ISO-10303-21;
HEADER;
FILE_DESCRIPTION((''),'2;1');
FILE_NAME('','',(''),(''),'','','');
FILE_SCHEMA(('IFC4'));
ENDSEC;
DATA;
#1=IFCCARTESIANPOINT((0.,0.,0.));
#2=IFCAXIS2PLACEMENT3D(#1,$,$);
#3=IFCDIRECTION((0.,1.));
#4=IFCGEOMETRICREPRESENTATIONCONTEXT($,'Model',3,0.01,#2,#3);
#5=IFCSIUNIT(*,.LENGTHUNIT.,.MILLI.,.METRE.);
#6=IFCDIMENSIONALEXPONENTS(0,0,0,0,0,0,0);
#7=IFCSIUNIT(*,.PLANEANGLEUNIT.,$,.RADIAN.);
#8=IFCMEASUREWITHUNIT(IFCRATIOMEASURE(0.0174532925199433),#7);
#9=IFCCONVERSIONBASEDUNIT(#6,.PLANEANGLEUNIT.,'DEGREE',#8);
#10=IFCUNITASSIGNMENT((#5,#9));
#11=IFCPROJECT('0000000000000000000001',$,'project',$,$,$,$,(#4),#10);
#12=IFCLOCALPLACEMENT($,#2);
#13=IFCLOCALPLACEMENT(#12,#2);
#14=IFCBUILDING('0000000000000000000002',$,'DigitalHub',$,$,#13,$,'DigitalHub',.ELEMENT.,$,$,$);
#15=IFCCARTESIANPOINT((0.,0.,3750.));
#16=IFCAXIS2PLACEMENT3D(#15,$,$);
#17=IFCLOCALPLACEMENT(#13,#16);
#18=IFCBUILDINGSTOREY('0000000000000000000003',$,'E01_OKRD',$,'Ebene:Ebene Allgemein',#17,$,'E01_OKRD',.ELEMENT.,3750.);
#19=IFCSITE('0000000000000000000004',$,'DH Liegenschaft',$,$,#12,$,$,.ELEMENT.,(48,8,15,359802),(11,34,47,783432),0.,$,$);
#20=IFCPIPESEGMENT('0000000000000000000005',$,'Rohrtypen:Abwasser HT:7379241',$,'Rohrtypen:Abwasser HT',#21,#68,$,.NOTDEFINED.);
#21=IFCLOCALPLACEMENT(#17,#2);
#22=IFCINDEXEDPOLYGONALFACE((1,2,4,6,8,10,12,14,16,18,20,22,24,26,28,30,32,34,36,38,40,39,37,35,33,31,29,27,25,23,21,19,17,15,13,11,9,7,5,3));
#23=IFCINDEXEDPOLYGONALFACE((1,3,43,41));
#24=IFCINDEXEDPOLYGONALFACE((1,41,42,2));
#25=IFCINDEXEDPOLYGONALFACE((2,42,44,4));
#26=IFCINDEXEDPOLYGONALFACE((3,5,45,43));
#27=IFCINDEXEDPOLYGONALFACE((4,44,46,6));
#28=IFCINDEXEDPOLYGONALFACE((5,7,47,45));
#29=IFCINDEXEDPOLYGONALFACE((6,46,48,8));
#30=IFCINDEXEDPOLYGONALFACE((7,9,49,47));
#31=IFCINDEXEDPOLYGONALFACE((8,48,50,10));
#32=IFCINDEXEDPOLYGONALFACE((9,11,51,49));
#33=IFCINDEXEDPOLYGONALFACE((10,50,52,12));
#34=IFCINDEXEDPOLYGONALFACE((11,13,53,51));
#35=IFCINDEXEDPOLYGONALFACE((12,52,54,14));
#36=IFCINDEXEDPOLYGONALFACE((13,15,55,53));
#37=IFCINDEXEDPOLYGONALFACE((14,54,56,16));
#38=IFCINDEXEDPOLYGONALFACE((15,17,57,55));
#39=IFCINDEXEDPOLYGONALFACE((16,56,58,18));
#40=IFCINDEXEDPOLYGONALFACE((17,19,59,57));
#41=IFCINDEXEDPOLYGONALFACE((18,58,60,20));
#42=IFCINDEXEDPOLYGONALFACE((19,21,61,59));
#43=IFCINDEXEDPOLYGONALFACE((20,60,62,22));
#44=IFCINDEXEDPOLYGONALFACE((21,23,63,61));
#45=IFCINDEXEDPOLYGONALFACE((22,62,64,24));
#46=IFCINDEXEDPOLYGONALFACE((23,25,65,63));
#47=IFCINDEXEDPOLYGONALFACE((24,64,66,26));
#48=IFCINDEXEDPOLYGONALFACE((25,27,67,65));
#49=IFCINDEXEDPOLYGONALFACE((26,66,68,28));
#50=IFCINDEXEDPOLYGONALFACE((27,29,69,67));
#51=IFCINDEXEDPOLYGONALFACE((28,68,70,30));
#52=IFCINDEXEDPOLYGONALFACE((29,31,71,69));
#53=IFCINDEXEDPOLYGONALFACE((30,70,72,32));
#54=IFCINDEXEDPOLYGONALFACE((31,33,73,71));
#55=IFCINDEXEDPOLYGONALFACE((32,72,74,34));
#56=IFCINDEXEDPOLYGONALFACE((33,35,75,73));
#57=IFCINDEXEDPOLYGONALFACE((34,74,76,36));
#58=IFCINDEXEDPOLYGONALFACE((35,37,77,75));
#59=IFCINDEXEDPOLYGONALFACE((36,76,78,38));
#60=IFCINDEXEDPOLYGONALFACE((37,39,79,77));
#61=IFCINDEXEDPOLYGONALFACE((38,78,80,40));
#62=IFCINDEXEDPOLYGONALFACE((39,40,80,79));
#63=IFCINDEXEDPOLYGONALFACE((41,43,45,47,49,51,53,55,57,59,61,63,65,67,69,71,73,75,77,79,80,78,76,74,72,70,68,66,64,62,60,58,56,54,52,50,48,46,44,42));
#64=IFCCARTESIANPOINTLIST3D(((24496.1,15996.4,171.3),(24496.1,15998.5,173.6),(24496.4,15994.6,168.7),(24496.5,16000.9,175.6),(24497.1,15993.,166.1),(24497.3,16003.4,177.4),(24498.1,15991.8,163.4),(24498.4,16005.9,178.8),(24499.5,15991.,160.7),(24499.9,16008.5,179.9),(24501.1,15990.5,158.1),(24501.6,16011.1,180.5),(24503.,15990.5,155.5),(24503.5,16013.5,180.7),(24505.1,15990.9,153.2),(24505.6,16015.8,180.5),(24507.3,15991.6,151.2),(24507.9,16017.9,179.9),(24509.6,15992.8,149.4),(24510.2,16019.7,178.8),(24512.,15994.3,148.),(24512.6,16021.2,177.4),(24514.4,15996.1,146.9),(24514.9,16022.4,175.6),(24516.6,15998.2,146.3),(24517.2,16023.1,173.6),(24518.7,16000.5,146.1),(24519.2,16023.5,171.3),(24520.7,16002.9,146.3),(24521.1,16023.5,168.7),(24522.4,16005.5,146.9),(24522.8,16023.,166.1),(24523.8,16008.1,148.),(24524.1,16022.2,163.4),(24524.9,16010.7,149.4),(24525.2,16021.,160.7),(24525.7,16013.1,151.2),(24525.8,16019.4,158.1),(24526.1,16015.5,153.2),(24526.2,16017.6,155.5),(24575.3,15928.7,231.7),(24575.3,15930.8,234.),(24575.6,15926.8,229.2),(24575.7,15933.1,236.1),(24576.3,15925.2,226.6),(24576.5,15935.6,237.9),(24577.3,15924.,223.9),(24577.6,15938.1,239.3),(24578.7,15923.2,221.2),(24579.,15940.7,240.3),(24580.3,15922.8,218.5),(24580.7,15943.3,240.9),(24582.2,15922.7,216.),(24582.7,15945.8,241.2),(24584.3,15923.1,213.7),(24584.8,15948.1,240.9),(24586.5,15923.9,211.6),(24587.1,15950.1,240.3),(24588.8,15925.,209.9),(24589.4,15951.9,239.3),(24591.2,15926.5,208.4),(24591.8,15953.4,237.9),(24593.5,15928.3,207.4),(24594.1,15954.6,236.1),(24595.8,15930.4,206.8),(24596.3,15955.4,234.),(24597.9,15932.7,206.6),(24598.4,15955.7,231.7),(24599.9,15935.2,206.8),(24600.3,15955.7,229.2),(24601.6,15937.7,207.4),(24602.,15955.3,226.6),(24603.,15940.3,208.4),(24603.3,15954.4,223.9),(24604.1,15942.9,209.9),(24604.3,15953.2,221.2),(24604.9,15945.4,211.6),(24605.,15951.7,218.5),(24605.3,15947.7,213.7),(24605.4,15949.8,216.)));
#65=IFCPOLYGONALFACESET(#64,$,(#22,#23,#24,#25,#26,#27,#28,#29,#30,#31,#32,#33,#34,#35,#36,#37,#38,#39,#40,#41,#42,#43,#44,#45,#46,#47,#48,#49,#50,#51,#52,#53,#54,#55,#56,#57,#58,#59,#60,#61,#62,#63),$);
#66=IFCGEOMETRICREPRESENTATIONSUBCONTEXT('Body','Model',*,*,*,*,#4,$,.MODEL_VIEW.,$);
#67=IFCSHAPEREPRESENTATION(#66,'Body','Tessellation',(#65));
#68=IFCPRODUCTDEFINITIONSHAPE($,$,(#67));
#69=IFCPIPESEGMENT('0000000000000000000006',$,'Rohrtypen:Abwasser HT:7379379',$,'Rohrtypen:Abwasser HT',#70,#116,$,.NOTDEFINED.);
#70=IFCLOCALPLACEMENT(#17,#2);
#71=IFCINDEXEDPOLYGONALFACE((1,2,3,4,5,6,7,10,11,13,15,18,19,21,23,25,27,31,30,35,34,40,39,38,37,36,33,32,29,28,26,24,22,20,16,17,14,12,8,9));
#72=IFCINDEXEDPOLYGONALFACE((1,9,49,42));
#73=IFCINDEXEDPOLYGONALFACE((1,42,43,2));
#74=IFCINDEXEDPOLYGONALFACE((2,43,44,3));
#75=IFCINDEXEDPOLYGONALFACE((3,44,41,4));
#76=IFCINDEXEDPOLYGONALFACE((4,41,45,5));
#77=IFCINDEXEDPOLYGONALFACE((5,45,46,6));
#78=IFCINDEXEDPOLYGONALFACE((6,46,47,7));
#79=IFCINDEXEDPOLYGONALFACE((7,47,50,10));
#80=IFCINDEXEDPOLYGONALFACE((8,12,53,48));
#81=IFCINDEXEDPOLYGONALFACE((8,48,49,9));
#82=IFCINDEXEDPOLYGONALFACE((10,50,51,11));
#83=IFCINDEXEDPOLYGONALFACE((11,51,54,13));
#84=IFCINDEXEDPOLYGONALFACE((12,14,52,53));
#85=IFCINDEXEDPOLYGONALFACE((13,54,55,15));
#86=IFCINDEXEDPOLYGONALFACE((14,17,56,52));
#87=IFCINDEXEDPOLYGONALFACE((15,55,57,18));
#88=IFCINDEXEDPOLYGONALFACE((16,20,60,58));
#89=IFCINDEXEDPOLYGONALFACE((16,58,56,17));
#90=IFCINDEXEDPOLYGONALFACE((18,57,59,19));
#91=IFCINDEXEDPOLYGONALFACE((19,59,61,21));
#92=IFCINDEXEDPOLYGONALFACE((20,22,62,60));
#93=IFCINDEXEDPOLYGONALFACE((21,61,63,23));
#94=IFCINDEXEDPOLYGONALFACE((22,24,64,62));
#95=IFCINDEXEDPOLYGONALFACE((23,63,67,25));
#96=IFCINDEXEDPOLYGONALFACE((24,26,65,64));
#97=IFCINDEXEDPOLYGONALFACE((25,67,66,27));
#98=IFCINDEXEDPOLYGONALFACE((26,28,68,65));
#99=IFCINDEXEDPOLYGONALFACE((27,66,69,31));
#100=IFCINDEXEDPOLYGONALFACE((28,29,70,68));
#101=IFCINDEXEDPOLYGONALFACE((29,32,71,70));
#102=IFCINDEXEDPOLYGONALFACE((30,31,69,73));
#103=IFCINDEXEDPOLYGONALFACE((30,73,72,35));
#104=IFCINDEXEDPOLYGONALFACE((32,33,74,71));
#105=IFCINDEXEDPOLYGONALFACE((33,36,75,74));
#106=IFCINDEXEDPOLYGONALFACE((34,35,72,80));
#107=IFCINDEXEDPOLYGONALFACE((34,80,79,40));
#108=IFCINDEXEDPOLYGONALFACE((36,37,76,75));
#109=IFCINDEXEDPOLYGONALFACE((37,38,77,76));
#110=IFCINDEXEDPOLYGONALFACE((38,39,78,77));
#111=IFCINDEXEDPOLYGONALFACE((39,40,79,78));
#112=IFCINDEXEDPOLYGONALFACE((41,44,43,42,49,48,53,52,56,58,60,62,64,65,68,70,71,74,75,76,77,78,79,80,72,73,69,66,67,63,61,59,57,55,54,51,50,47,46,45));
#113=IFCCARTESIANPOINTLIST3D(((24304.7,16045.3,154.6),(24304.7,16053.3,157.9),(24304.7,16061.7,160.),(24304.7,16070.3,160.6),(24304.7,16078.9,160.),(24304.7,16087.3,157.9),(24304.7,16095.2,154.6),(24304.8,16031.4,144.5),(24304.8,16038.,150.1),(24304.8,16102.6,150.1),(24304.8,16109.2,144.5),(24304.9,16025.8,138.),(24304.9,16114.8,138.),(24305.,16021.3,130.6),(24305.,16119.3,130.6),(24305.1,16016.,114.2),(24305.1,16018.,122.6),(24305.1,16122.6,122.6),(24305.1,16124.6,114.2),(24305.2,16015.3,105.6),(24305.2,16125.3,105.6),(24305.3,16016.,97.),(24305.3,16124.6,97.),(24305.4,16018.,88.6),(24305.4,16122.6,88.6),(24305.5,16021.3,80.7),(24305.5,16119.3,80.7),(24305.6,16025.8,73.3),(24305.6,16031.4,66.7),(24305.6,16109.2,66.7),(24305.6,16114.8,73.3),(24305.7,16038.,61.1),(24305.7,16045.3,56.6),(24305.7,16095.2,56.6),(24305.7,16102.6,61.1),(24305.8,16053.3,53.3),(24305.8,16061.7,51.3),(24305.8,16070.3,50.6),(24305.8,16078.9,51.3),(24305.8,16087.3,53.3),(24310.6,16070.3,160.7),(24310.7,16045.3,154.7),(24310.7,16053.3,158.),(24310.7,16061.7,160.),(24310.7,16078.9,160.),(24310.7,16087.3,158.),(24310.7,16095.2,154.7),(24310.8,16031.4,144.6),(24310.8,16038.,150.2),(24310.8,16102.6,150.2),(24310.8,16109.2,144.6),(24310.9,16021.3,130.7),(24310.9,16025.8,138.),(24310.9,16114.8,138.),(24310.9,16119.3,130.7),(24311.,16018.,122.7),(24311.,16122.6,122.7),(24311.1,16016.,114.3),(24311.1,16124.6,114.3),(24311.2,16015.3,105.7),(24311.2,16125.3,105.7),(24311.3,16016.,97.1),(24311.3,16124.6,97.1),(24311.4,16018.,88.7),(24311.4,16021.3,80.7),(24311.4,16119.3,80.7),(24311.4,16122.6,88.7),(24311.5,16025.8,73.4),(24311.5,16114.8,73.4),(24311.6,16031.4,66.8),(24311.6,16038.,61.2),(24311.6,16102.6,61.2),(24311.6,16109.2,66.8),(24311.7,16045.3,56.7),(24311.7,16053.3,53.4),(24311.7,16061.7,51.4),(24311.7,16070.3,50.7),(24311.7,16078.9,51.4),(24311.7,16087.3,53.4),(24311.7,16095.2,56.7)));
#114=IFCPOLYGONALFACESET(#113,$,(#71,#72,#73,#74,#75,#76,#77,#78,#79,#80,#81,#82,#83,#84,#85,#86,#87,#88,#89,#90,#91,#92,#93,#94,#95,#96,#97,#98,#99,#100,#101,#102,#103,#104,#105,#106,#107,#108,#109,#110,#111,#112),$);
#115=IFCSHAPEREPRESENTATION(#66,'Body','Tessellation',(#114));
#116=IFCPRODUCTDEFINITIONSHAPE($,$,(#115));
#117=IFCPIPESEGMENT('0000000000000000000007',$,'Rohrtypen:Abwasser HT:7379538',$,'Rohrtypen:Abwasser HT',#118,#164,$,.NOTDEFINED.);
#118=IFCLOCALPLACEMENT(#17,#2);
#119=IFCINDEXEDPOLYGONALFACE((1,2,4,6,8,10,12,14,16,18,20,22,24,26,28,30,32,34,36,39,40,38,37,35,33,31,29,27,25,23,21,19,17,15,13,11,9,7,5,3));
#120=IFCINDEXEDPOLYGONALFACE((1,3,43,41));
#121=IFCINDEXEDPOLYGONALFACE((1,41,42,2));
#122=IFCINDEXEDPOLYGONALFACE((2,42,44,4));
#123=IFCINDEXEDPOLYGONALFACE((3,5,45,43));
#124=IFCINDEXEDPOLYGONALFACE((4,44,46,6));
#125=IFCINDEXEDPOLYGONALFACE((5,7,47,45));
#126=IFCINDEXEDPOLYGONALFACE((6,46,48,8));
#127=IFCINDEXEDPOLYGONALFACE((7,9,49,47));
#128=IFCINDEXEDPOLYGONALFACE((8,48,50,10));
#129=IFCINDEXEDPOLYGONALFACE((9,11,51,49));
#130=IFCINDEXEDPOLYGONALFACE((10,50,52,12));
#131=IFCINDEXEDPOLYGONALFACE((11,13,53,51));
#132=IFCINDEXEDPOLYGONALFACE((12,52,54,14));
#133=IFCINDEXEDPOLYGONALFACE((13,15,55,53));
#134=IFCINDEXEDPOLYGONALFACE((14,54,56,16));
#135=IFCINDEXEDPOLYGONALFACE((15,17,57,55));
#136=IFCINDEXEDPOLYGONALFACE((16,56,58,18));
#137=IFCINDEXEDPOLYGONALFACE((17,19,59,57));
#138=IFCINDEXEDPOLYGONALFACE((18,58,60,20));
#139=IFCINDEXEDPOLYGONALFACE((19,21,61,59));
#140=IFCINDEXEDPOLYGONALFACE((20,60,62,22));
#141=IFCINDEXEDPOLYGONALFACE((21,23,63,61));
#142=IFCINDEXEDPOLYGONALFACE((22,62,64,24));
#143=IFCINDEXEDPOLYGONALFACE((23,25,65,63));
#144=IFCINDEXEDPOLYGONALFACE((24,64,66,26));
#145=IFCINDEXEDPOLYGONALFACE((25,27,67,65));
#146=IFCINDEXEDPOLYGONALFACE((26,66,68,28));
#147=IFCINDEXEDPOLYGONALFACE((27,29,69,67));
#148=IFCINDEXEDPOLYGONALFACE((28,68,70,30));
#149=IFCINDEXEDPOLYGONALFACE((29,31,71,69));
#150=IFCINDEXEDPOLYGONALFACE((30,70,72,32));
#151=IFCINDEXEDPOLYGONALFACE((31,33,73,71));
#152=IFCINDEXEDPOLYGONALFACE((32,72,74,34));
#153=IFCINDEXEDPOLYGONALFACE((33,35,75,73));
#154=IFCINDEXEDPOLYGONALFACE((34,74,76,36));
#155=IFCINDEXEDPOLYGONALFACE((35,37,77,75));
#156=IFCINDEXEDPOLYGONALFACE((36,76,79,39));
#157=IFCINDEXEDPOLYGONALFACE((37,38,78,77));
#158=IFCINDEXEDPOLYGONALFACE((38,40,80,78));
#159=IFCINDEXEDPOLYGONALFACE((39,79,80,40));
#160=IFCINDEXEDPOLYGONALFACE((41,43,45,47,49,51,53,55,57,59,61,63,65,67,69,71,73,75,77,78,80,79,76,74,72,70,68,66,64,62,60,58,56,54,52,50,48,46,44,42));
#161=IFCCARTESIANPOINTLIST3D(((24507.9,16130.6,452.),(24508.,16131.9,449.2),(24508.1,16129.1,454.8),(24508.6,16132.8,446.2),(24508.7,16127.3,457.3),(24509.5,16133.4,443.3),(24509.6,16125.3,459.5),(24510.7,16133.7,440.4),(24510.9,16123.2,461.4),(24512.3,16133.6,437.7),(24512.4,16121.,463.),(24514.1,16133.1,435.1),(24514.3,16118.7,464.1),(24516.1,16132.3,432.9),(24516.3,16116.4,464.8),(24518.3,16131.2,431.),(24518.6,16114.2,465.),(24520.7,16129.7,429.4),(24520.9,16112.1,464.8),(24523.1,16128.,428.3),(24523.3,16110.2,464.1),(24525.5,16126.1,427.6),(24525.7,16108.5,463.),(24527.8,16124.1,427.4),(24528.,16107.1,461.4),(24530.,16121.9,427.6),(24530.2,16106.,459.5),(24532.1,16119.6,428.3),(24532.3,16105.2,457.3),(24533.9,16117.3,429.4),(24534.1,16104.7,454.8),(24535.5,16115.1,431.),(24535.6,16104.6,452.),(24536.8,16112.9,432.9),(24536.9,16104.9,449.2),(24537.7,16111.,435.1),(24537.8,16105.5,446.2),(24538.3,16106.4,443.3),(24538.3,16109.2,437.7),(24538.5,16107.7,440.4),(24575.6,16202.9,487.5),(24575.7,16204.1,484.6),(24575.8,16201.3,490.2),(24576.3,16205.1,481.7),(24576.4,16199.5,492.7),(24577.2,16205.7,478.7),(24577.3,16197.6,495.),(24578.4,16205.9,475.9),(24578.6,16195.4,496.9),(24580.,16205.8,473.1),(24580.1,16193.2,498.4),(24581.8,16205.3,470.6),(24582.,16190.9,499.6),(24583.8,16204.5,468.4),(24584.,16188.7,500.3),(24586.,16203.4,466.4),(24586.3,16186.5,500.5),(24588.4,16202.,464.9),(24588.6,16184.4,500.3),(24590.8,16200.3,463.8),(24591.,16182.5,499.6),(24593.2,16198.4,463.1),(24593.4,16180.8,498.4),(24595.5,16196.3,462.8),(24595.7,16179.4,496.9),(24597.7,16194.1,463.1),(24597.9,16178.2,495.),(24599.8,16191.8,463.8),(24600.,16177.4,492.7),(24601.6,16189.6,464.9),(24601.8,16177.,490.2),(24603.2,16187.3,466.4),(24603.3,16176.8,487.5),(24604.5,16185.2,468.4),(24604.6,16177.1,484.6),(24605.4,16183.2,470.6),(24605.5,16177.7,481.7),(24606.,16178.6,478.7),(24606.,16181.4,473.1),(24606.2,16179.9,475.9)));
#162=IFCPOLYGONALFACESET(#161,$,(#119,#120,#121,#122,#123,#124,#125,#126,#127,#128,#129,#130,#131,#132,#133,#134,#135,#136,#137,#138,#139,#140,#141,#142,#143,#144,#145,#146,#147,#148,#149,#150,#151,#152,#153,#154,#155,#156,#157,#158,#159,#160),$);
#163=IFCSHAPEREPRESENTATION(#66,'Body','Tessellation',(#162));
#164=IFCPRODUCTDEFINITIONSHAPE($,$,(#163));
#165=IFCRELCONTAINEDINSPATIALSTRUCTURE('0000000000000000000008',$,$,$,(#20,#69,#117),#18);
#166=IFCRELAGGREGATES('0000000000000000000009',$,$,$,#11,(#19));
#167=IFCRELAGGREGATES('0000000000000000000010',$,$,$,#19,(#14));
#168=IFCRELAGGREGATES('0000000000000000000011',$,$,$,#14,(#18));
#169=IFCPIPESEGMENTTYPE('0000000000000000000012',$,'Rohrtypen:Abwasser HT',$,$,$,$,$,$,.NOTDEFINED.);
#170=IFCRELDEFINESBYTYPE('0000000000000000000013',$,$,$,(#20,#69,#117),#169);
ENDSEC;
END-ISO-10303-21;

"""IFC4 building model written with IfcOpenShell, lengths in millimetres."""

from ifc_helpers import new_model, entity, si_unit, converted_unit, direction, frame, origin, place, context, subcontext, project, spatial, indexed_curve, outline, extrude, type_object, element, save


model = new_model("IFC4")

# Units and contexts
model_context = context("Model", 3, precision=0.01, world=origin(), true_north=direction((0.0, 1.0)))
body_context = subcontext(model_context, "Body", "Model", "MODEL_VIEW")
ifc_project = project(units=[si_unit("LENGTHUNIT", "METRE", prefix="MILLI"), converted_unit("PLANEANGLEUNIT", "DEGREE", entity("IfcRatioMeasure", 0.0174532925199433), si_unit("PLANEANGLEUNIT", "RADIAN"), dimensions=[0, 0, 0, 0, 0, 0, 0])], contexts=[model_context])

# Site, building, storey
site_placement = place(None, origin())
site = spatial("IfcSite", under=ifc_project, at=site_placement, Name="DH Liegenschaft", CompositionType="ELEMENT", RefLatitude=(48, 8, 15, 359802), RefLongitude=(11, 34, 47, 783432), RefElevation=0.0)
building_placement = place(site_placement, origin())
building = spatial("IfcBuilding", under=site, at=building_placement, Name="DigitalHub", LongName="DigitalHub", CompositionType="ELEMENT")
storey_placement = place(building_placement, frame((0.0, 0.0, 3750.0)))
storey = spatial("IfcBuildingStorey", under=building, at=storey_placement, Name="E01_OKRD", ObjectType="Ebene:Ebene Allgemein", LongName="E01_OKRD", CompositionType="ELEMENT", Elevation=3750.0)

# Pipe segments
pipe_segment_type_1 = type_object("IfcPipeSegmentType", Name="Rohrtypen:Abwasser HT", PredefinedType="NOTDEFINED")
pipe_segment_1_placement = place(storey_placement, frame((24494.5, 15921.2, 144.5)))
element("IfcPipeSegment", 1, at=pipe_segment_1_placement, inside=storey, type_object=pipe_segment_type_1, Name="Rohrtypen:Abwasser HT:7379241", ObjectType="Rohrtypen:Abwasser HT", PredefinedType="NOTDEFINED", context=body_context, shape_type="SweptSolid", body=[
    extrude(outline(indexed_curve([(20.0, 0.0), (19.8, 3.1), (19.0, 6.2), (17.8, 9.1), (16.2, 11.8), (14.1, 14.1), (11.8, 16.2), (9.1, 17.8), (6.2, 19.0), (3.1, 19.8), (0.0, 20.0), (-3.1, 19.8), (-6.2, 19.0), (-9.1, 17.8), (-11.8, 16.2), (-14.1, 14.1), (-16.2, 11.8), (-17.8, 9.1), (-19.0, 6.2), (-19.8, 3.1), (-20.0, 0.0), (-19.8, -3.1), (-19.0, -6.2), (-17.8, -9.1), (-16.2, -11.8), (-14.1, -14.1), (-11.8, -16.2), (-9.1, -17.8), (-6.2, -19.0), (-3.1, -19.8), (0.0, -20.0), (3.1, -19.8), (6.2, -19.0), (9.1, -17.8), (11.8, -16.2), (14.1, -14.1), (16.2, -11.8), (17.8, -9.1), (19.0, -6.2), (19.8, -3.1), (20.0, 0.0)], self_intersect=False)), frame((16.7, 85.8, 18.9), z_axis=(0.65717, -0.562452, 0.501772), x_axis=(0.650234, 0.759734, 0.0)), (0.0, 0.0, 1.0), 120.5),
])
pipe_segment_2_placement = place(storey_placement, frame((24303.1, 16013.7, 49.0)))
element("IfcPipeSegment", 2, at=pipe_segment_2_placement, inside=storey, type_object=pipe_segment_type_1, Name="Rohrtypen:Abwasser HT:7379379", ObjectType="Rohrtypen:Abwasser HT", PredefinedType="NOTDEFINED", context=body_context, shape_type="SweptSolid", body=[
    extrude(outline(indexed_curve([(55.0, 0.0), (54.3, 8.6), (52.3, 17.0), (49.0, 25.0), (44.5, 32.3), (38.9, 38.9), (32.3, 44.5), (25.0, 49.0), (17.0, 52.3), (8.6, 54.3), (0.0, 55.0), (-8.6, 54.3), (-17.0, 52.3), (-25.0, 49.0), (-32.3, 44.5), (-38.9, 38.9), (-44.5, 32.3), (-49.0, 25.0), (-52.3, 17.0), (-54.3, 8.6), (-55.0, 0.0), (-54.3, -8.6), (-52.3, -17.0), (-49.0, -25.0), (-44.5, -32.3), (-38.9, -38.9), (-32.3, -44.5), (-25.0, -49.0), (-17.0, -52.3), (-8.6, -54.3), (0.0, -55.0), (8.6, -54.3), (17.0, -52.3), (25.0, -49.0), (32.3, -44.5), (38.9, -38.9), (44.5, -32.3), (49.0, -25.0), (52.3, -17.0), (54.3, -8.6), (55.0, 0.0)], self_intersect=False)), frame((2.1, 56.6, 56.6), z_axis=(0.99995, 0.0, 0.01), x_axis=(0.0, -1.0, 0.0)), (0.0, 0.0, 1.0), 6.0),
])
pipe_segment_3_placement = place(storey_placement, frame((24506.3, 16103.1, 425.8)))
element("IfcPipeSegment", 3, at=pipe_segment_3_placement, inside=storey, type_object=pipe_segment_type_1, Name="Rohrtypen:Abwasser HT:7379538", ObjectType="Rohrtypen:Abwasser HT", PredefinedType="NOTDEFINED", context=body_context, shape_type="SweptSolid", body=[
    extrude(outline(indexed_curve([(20.0, 0.0), (19.8, 3.1), (19.0, 6.2), (17.8, 9.1), (16.2, 11.8), (14.1, 14.1), (11.8, 16.2), (9.1, 17.8), (6.2, 19.0), (3.1, 19.8), (0.0, 20.0), (-3.1, 19.8), (-6.2, 19.0), (-9.1, 17.8), (-11.8, 16.2), (-14.1, 14.1), (-16.2, 11.8), (-17.8, 9.1), (-19.0, 6.2), (-19.8, 3.1), (-20.0, 0.0), (-19.8, -3.1), (-19.0, -6.2), (-17.8, -9.1), (-16.2, -11.8), (-14.1, -14.1), (-11.8, -16.2), (-9.1, -17.8), (-6.2, -19.0), (-3.1, -19.8), (0.0, -20.0), (3.1, -19.8), (6.2, -19.0), (9.1, -17.8), (11.8, -16.2), (14.1, -14.1), (16.2, -11.8), (17.8, -9.1), (19.0, -6.2), (19.8, -3.1), (20.0, 0.0)], self_intersect=False)), frame((16.9, 16.1, 20.4), z_axis=(0.643762, 0.686922, 0.337205), x_axis=(0.729658, -0.683813, 0.0)), (0.0, 0.0, 1.0), 105.2),
])

save(model, "model.ifc")
